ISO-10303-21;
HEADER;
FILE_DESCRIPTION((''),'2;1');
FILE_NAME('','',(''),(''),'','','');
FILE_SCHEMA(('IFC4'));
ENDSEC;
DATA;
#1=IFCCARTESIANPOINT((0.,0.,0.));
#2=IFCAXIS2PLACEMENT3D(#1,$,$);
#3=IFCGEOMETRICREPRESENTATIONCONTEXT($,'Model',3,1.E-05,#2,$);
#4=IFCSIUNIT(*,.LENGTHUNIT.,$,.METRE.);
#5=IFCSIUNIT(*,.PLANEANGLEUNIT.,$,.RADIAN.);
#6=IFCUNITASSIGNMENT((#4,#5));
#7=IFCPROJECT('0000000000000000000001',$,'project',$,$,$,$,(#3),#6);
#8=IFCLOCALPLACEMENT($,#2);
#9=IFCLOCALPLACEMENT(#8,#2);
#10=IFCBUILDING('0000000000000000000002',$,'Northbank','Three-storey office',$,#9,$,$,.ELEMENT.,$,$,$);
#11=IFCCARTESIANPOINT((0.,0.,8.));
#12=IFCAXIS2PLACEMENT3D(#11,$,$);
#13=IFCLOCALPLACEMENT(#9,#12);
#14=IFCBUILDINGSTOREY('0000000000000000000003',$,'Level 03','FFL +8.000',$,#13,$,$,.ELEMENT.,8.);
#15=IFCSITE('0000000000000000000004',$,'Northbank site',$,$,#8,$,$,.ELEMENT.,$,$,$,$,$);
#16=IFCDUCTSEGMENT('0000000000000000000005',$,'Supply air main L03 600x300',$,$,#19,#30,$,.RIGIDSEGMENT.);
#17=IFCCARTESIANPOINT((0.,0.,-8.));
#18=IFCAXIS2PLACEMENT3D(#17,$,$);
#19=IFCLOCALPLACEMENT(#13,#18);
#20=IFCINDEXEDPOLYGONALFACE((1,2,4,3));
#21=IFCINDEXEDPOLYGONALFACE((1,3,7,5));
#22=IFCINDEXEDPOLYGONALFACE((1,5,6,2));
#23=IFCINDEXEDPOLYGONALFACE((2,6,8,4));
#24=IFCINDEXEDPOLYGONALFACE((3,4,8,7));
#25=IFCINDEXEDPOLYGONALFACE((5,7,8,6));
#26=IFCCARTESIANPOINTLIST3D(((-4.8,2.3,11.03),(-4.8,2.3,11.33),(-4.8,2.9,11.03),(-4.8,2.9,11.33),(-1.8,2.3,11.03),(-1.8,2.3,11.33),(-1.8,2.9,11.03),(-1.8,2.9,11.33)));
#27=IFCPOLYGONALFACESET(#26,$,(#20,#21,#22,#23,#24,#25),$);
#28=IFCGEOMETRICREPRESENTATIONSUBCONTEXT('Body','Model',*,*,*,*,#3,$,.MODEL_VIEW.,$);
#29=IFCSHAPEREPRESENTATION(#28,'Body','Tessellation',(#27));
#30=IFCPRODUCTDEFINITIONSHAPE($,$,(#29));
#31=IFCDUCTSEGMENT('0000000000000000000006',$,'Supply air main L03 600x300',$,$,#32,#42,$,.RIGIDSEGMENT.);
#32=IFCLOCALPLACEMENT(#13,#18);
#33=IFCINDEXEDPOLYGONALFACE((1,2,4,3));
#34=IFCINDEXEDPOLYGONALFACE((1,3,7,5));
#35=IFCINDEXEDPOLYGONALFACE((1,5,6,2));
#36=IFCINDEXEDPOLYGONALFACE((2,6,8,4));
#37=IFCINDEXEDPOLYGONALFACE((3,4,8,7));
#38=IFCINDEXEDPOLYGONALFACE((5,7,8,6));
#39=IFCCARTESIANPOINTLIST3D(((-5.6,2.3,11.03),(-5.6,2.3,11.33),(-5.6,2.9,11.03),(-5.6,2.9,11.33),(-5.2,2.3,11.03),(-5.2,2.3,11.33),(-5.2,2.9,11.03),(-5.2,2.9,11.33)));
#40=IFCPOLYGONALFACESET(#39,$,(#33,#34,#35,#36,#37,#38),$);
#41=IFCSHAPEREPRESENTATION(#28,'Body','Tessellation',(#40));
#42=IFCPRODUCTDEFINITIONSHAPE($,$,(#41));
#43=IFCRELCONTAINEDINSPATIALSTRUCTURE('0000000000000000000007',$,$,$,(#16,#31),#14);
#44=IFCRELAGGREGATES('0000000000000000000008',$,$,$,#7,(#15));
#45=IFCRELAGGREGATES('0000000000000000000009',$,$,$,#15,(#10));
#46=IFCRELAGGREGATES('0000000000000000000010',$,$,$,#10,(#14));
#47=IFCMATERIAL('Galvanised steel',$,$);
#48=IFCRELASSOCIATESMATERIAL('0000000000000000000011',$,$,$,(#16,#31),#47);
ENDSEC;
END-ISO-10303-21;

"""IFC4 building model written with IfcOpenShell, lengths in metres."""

from ifc_helpers import new_model, si_unit, frame, origin, place, context, subcontext, project, spatial, rectangle, extrude, material, element, save


model = new_model("IFC4")

# Units and contexts
model_context = context("Model", 3, precision=1e-05, world=origin())
body_context = subcontext(model_context, "Body", "Model", "MODEL_VIEW")
ifc_project = project(units=[si_unit("LENGTHUNIT", "METRE"), si_unit("PLANEANGLEUNIT", "RADIAN")], contexts=[model_context])

# Site, building, storey
site_placement = place(None, origin())
site = spatial("IfcSite", under=ifc_project, at=site_placement, Name="Northbank site", CompositionType="ELEMENT")
building_placement = place(site_placement, origin())
building = spatial("IfcBuilding", under=site, at=building_placement, Name="Northbank", Description="Three-storey office", CompositionType="ELEMENT")
storey_placement = place(building_placement, frame((0.0, 0.0, 8.0)))
storey = spatial("IfcBuildingStorey", under=building, at=storey_placement, Name="Level 03", Description="FFL +8.000", CompositionType="ELEMENT", Elevation=8.0)

# Shared definitions
ifc_material_1 = material(Name="Galvanised steel")

# Duct segments
duct_segment_1_placement = place(storey_placement, frame((0.0, 0.0, -8.0)))
element("IfcDuctSegment", 1, at=duct_segment_1_placement, inside=storey, material=ifc_material_1, Name="Supply air main L03 600x300", PredefinedType="RIGIDSEGMENT", context=body_context, shape_type="SweptSolid", body=[
    extrude(rectangle(XDim=0.6, YDim=0.3), frame((-1.8, 2.6, 11.18), z_axis=(-1.0, 0.0, 0.0), x_axis=(0.0, -1.0, 0.0)), (0.0, 0.0, 1.0), 3.0),
])
duct_segment_2_placement = place(storey_placement, frame((0.0, 0.0, -8.0)))
element("IfcDuctSegment", 2, at=duct_segment_2_placement, inside=storey, material=ifc_material_1, Name="Supply air main L03 600x300", PredefinedType="RIGIDSEGMENT", context=body_context, shape_type="SweptSolid", body=[
    extrude(rectangle(XDim=0.6, YDim=0.3), frame((-5.2, 2.6, 11.18), z_axis=(-1.0, 0.0, 0.0), x_axis=(0.0, -1.0, 0.0)), (0.0, 0.0, 1.0), 0.4),
])

save(model, "model.ifc")
